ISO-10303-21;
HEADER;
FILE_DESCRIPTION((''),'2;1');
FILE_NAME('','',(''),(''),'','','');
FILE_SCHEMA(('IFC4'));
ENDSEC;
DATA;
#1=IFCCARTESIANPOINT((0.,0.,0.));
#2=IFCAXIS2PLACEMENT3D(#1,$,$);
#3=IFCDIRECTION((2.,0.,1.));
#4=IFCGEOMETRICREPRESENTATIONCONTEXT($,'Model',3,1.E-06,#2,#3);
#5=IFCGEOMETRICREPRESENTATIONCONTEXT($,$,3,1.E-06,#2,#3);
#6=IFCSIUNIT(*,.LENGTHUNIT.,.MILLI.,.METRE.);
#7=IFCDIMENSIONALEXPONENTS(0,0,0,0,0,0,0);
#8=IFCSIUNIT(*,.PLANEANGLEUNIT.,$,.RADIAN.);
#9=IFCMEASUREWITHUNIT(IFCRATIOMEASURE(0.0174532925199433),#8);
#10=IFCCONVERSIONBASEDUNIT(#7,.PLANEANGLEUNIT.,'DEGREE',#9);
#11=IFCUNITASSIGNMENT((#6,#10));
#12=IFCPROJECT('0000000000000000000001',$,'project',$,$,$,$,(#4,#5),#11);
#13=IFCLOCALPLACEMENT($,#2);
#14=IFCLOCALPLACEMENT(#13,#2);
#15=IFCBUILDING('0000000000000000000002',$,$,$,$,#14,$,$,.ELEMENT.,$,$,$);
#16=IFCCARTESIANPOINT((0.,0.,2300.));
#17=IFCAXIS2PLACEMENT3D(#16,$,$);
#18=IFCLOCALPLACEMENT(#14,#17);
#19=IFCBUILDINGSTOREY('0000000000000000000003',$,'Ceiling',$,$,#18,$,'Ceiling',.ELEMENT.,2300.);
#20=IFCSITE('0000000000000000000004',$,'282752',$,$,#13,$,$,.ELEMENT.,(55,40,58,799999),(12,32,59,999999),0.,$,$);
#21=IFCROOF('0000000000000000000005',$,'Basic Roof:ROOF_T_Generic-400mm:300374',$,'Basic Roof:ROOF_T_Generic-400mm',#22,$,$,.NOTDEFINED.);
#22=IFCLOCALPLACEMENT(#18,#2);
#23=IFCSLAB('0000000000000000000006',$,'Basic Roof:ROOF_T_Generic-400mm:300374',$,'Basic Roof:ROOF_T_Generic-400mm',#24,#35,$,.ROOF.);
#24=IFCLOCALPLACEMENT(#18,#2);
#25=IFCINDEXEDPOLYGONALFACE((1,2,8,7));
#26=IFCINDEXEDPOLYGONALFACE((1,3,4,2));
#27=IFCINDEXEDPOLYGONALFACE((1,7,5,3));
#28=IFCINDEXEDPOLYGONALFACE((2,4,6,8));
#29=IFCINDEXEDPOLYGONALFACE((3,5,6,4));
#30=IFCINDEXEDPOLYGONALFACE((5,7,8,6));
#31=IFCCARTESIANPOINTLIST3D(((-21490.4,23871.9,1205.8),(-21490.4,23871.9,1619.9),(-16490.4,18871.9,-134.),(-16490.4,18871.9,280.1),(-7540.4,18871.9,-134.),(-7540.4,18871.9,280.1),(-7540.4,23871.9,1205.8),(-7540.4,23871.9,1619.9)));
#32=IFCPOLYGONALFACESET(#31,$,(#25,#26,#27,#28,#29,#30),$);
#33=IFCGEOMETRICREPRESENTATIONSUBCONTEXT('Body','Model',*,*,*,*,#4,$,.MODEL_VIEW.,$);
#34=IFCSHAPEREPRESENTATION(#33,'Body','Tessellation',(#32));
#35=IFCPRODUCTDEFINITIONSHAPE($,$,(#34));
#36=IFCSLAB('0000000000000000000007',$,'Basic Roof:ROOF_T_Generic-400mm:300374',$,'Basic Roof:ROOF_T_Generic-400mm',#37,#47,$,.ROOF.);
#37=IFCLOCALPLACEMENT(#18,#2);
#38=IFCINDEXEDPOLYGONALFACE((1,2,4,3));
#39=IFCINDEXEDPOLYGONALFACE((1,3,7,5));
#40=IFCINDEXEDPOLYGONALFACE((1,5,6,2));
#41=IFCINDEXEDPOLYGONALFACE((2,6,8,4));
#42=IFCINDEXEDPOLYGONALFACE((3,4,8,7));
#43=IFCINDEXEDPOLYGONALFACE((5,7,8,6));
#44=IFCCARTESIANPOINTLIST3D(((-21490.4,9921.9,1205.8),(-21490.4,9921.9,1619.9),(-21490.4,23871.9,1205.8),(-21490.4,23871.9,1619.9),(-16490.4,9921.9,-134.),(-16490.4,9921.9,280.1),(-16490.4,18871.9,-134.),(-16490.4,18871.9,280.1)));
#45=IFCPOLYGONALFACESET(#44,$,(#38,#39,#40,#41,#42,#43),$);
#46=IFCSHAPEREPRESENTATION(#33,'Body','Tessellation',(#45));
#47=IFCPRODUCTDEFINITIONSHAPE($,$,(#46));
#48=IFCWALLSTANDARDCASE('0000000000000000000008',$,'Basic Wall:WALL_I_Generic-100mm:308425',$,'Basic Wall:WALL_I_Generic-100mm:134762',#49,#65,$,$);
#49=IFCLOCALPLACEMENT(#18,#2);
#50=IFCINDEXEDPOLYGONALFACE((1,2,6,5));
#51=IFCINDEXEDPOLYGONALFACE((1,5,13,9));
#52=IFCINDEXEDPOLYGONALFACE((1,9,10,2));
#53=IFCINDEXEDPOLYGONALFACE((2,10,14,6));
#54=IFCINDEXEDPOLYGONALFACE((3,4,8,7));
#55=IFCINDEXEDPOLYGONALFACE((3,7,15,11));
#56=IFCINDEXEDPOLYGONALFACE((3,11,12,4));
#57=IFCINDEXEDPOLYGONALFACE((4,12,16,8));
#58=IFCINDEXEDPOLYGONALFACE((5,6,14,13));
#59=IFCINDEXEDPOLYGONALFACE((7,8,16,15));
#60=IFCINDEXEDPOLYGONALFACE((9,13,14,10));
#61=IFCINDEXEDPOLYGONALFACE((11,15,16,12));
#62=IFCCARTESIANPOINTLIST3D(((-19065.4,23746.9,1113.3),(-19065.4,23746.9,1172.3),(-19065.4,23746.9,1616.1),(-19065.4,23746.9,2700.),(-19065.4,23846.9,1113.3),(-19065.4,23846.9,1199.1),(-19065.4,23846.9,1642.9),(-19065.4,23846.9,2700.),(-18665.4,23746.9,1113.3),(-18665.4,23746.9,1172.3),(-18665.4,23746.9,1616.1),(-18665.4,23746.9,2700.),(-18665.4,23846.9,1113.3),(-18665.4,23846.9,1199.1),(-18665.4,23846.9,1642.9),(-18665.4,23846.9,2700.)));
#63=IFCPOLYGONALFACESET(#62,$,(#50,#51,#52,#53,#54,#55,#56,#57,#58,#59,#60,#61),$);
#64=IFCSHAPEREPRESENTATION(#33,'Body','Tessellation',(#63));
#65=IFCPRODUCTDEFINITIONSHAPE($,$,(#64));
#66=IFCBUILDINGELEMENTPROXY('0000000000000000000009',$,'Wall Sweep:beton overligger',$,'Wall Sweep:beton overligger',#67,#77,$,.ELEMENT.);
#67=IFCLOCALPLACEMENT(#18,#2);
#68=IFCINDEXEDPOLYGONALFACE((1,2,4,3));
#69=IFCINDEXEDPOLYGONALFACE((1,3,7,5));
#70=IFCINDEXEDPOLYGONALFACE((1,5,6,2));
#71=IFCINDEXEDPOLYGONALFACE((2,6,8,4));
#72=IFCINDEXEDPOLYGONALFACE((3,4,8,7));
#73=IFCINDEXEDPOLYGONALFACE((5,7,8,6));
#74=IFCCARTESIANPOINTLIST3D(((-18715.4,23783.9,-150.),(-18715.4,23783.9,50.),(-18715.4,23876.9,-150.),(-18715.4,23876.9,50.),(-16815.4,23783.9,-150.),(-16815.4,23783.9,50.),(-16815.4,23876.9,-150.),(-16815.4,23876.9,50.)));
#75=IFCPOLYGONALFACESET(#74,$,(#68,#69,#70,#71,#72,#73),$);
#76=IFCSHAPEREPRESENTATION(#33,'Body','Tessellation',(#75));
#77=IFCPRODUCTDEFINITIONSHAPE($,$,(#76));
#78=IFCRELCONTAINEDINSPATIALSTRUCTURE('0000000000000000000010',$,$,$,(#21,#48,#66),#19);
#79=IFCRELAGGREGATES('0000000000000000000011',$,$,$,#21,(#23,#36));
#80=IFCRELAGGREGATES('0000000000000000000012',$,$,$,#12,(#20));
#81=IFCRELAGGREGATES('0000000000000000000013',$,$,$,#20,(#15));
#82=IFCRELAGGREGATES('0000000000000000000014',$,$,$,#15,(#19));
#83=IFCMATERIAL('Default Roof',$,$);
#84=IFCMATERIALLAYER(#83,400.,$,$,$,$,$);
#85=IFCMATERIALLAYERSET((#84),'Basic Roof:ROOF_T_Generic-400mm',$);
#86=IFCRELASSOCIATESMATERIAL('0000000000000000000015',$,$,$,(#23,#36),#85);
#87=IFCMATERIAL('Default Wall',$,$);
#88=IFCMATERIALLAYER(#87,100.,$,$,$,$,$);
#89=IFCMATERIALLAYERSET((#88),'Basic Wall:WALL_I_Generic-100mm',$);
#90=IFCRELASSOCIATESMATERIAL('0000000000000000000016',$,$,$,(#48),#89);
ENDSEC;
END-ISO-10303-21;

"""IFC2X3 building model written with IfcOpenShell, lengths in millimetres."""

from ifc_helpers import new_model, entity, si_unit, converted_unit, direction, frame, frame_2d, origin, origin_2d_with_axis, place, context, subcontext, project, spatial, polyline, rectangle, outline, extrude, material, layer, layer_set, layer_usage, element, aggregate, save


model = new_model("IFC2X3")

# Units and contexts
model_context = context("Model", 3, precision=1e-06, world=origin(), true_north=direction((2.0, 0.0, 1.0)))
context_of_model = context(None, 3, precision=1e-06, world=origin(), true_north=direction((2.0, 0.0, 1.0)))
body_context = subcontext(model_context, "Body", "Model", "MODEL_VIEW")
ifc_project = project(units=[si_unit("LENGTHUNIT", "METRE", prefix="MILLI"), converted_unit("PLANEANGLEUNIT", "DEGREE", entity("IfcRatioMeasure", 0.0174532925199433), si_unit("PLANEANGLEUNIT", "RADIAN"), dimensions=[0, 0, 0, 0, 0, 0, 0])], contexts=[model_context, context_of_model])

# Site, building, storey
site_placement = place(None, origin())
site = spatial("IfcSite", under=ifc_project, at=site_placement, Name="282752", CompositionType="ELEMENT", RefLatitude=(55, 40, 58, 799999), RefLongitude=(12, 32, 59, 999999), RefElevation=0.0)
building_placement = place(site_placement, origin())
building = spatial("IfcBuilding", under=site, at=building_placement, CompositionType="ELEMENT")
storey_placement = place(building_placement, frame((0.0, 0.0, 2300.0)))
storey = spatial("IfcBuildingStorey", under=building, at=storey_placement, Name="Ceiling", LongName="Ceiling", CompositionType="ELEMENT", Elevation=2300.0)

# Roof, slabs
roof_placement = place(storey_placement, origin())
roof = element("IfcRoof", 1, at=roof_placement, inside=storey, Name="Basic Roof:ROOF_T_Generic-400mm:300374", ObjectType="Basic Roof:ROOF_T_Generic-400mm", ShapeType="NOTDEFINED")
ifc_material_1 = material(Name="Default Roof")
ifc_layer_1 = layer(ifc_material_1, 400.0)
ifc_layer_set_1 = layer_set([ifc_layer_1], Name="Basic Roof:ROOF_T_Generic-400mm")
slab_1_placement = place(roof_placement, frame((-21490.4, 9921.9, -134.0)))
slab_1 = element("IfcSlab", 2, at=slab_1_placement, material=ifc_layer_set_1, Name="Basic Roof:ROOF_T_Generic-400mm:300374", ObjectType="Basic Roof:ROOF_T_Generic-400mm", PredefinedType="ROOF", context=body_context, shape_type="SweptSolid", body=[
    extrude(outline(polyline([(-1975.0, -2588.2), (6975.0, -2588.2), (6975.0, 2588.2), (-6975.0, 2588.2), (-1975.0, -2588.2)])), frame((6975.0, 11450.0, 669.9), z_axis=(0.0, -0.258819, 0.965926), x_axis=(1.0, 0.0, 0.0)), (0.0, 0.258819, 0.965926), 414.1),
])
slab_2_placement = place(roof_placement, frame((-21490.4, 9921.9, -134.0)))
slab_2 = element("IfcSlab", 3, at=slab_2_placement, material=ifc_layer_set_1, Name="Basic Roof:ROOF_T_Generic-400mm:300374", ObjectType="Basic Roof:ROOF_T_Generic-400mm", PredefinedType="ROOF", context=body_context, shape_type="SweptSolid", body=[
    extrude(outline(polyline([(-2588.2, -6975.0), (2588.2, -6975.0), (2588.2, 1975.0), (-2588.2, 6975.0), (-2588.2, -6975.0)])), frame((2500.0, 6975.0, 669.9), z_axis=(0.258819, 0.0, 0.965926), x_axis=(0.965926, 0.0, -0.258819)), (-0.258819, 0.0, 0.965926), 414.1),
])
aggregate(roof, [slab_1, slab_2])

# Wall, opening
ifc_material_2 = material(Name="Default Wall")
ifc_layer_2 = layer(ifc_material_2, 100.0)
ifc_layer_set_2 = layer_set([ifc_layer_2], Name="Basic Wall:WALL_I_Generic-100mm")
ifc_layer_usage = layer_usage(ifc_layer_set_2, "AXIS2", "NEGATIVE", 50.0)
wall_placement = place(storey_placement, frame((-18665.4, 23796.9, 1113.3), z_axis=(0.0, 0.0, 1.0), x_axis=(-1.0, 0.0, 0.0)))
wall = element("IfcWallStandardCase", 4, at=wall_placement, inside=storey, material=ifc_layer_usage, Name="Basic Wall:WALL_I_Generic-100mm:308425", ObjectType="Basic Wall:WALL_I_Generic-100mm:134762", context=body_context, shape_type="SweptSolid", body=[
    extrude(rectangle(XDim=400.0, YDim=100.0, at=frame_2d((200.0, 0.0), x_axis=(-1.0, 0.0))), origin(), (0.0, 0.0, 1.0), 1586.7),
])
opening_placement = place(storey_placement, frame((-18665.4, 23796.9, 1113.3), z_axis=(0.0, 0.0, 1.0), x_axis=(-1.0, 0.0, 0.0)))
element("IfcOpeningElement", 5, at=opening_placement, cuts=wall, ObjectType="Opening", context=body_context, shape_type="SweptSolid", body=[
    extrude(rectangle(XDim=103.5, YDim=400.0, at=frame_2d((0.0, 0.0), x_axis=(0.0, 1.0))), frame((200.0, 0.0, 72.3), z_axis=(0.0, 0.258819, 0.965926), x_axis=(1.0, 0.0, 0.0)), (0.0, -0.258819, 0.965926), 443.8),
])

# Building element proxy
proxy_1_placement = place(storey_placement, origin())
element("IfcBuildingElementProxy", 6, at=proxy_1_placement, inside=storey, Name="Wall Sweep:beton overligger", ObjectType="Wall Sweep:beton overligger", CompositionType="ELEMENT", context=body_context, shape_type="SweptSolid", body=[
    extrude(rectangle(XDim=1900.0, YDim=93.0, at=origin_2d_with_axis()), frame((-17765.4, 23830.4, -150.0)), (0.0, 0.0, 1.0), 200.0),
])

save(model, "model.ifc")
